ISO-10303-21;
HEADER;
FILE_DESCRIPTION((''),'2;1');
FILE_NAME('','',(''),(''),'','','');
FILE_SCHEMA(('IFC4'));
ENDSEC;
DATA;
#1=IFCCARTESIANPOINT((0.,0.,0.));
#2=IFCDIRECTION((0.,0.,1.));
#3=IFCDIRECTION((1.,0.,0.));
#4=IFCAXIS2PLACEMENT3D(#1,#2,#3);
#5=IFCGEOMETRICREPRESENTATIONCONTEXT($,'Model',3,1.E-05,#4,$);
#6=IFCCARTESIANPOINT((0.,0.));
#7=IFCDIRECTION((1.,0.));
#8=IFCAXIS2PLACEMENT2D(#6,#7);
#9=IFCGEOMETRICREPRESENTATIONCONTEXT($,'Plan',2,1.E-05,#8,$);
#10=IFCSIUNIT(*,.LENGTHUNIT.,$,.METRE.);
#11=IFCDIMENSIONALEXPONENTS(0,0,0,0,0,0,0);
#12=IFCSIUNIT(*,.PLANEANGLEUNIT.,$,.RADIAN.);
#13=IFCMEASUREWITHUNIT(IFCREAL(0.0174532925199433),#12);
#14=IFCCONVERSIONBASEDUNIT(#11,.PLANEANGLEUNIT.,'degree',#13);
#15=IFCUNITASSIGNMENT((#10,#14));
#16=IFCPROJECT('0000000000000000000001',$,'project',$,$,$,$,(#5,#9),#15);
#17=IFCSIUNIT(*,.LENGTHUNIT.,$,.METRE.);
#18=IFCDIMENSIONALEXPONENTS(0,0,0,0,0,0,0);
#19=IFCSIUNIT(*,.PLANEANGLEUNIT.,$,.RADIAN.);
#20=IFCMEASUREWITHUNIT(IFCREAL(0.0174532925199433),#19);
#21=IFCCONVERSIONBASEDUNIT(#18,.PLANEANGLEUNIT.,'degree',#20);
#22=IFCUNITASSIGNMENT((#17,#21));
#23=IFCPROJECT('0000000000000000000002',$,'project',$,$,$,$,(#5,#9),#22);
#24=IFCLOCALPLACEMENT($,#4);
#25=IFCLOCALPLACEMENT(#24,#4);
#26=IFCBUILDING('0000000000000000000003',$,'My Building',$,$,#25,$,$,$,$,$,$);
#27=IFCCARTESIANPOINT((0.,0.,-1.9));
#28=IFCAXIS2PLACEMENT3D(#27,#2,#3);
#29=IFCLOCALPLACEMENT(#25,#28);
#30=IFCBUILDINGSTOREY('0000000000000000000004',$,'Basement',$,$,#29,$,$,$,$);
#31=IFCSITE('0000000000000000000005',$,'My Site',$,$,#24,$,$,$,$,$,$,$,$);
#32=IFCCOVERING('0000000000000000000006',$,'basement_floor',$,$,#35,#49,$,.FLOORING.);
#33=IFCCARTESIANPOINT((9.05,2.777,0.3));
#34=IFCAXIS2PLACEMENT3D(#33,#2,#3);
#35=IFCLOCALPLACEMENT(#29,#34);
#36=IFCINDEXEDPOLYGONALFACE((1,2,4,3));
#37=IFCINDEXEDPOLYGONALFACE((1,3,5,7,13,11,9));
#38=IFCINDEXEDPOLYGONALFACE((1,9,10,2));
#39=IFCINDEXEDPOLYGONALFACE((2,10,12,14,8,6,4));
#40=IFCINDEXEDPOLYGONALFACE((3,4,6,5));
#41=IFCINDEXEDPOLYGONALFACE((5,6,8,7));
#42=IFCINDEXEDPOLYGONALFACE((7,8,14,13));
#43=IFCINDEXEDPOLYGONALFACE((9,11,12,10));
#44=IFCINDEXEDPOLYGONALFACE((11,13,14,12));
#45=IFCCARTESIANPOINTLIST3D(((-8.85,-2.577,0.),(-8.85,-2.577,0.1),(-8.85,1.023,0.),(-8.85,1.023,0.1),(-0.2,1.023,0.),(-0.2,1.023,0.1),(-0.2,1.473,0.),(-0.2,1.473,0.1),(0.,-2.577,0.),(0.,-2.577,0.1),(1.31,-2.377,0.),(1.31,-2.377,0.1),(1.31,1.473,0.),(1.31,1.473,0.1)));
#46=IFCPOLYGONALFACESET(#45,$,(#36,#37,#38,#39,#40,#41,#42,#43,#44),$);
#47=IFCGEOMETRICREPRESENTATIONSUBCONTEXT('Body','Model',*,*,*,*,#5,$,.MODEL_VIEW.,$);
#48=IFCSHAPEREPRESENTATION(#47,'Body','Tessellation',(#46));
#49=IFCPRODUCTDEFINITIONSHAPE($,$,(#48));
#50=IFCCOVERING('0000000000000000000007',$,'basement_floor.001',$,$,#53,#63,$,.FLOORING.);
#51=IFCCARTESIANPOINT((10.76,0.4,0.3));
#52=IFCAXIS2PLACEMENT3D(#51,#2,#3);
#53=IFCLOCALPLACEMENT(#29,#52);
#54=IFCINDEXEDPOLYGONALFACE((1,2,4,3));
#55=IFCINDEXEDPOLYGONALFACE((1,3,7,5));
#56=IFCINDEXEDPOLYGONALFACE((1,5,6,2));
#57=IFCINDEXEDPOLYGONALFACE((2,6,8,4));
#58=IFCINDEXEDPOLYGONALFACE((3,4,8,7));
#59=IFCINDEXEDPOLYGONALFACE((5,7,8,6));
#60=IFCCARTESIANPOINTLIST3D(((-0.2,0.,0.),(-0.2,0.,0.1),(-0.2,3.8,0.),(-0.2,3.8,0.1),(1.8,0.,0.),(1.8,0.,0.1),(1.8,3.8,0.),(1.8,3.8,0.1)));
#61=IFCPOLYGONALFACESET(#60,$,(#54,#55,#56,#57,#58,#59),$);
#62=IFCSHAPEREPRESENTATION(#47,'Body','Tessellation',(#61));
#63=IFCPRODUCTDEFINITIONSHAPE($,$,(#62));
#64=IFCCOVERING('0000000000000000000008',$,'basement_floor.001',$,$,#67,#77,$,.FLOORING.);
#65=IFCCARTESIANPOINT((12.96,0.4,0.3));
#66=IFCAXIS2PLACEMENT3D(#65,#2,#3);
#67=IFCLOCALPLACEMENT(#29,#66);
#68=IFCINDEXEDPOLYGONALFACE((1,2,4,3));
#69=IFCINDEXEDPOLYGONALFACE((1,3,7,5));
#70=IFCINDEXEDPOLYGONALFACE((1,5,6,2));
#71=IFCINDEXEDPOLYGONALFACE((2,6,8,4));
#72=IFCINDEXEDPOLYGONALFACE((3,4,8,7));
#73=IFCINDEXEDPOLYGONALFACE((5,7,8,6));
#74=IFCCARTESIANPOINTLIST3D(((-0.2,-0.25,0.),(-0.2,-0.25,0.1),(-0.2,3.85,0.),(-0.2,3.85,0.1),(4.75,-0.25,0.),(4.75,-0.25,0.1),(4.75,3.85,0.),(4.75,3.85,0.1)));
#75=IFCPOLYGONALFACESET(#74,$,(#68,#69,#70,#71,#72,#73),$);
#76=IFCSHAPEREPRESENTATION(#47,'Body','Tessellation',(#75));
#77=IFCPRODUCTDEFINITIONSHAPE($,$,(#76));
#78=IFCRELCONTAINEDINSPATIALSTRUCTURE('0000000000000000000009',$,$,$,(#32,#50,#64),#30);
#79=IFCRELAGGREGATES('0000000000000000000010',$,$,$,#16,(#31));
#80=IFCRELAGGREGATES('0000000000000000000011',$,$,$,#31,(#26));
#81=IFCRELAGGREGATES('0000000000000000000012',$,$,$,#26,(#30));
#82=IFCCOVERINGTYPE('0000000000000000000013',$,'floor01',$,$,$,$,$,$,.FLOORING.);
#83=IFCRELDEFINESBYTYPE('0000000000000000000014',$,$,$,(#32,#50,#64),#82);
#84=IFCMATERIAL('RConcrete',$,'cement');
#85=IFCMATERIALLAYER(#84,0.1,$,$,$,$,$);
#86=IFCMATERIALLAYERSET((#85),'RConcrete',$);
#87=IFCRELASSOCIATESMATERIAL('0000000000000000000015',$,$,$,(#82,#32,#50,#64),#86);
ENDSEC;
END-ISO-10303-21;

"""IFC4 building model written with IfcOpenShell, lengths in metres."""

from ifc_helpers import new_model, entity, si_unit, converted_unit, frame, origin_with_axes, origin_2d_with_axis, place, context, subcontext, project, spatial, line, indexed_curve, outline, extrude, material, layer, layer_set, layer_usage, type_object, element, save


model = new_model("IFC4")

# Units and contexts
model_context = context("Model", 3, precision=1e-05, world=origin_with_axes())
plan_context = context("Plan", 2, precision=1e-05, world=origin_2d_with_axis())
body_context = subcontext(model_context, "Body", "Model", "MODEL_VIEW")
ifc_project_1 = project(units=[si_unit("LENGTHUNIT", "METRE"), converted_unit("PLANEANGLEUNIT", "degree", entity("IfcReal", 0.0174532925199433), si_unit("PLANEANGLEUNIT", "RADIAN"), dimensions=[0, 0, 0, 0, 0, 0, 0])], contexts=[model_context, plan_context])
ifc_project_2 = project(units=[si_unit("LENGTHUNIT", "METRE"), converted_unit("PLANEANGLEUNIT", "degree", entity("IfcReal", 0.0174532925199433), si_unit("PLANEANGLEUNIT", "RADIAN"), dimensions=[0, 0, 0, 0, 0, 0, 0])], contexts=[model_context, plan_context])

# Site, building, storey
site_placement = place(None, origin_with_axes())
site = spatial("IfcSite", under=ifc_project_1, at=site_placement, Name="My Site")
building_placement = place(site_placement, origin_with_axes())
building = spatial("IfcBuilding", under=site, at=building_placement, Name="My Building")
storey_placement = place(building_placement, frame((0.0, 0.0, -1.9), z_axis=(0.0, 0.0, 1.0), x_axis=(1.0, 0.0, 0.0)))
storey = spatial("IfcBuildingStorey", under=building, at=storey_placement, Name="Basement")

# Shared definitions
ifc_material_1 = material(Name="RConcrete", Category="cement")

# Coverings
ifc_layer_1 = layer(ifc_material_1, 0.1)
ifc_layer_set_1 = layer_set([ifc_layer_1], Name="RConcrete")
ifc_layer_usage_1 = layer_usage(ifc_layer_set_1, "AXIS3", "POSITIVE", 0.0)
covering_type = type_object("IfcCoveringType", Name="floor01", PredefinedType="FLOORING", material=ifc_layer_set_1)
covering_1_placement = place(storey_placement, frame((9.05, 2.777, 0.3), z_axis=(0.0, 0.0, 1.0), x_axis=(1.0, 0.0, 0.0)))
element("IfcCovering", 1, at=covering_1_placement, inside=storey, type_object=covering_type, material=ifc_layer_usage_1, Name="basement_floor", PredefinedType="FLOORING", context=body_context, shape_type="SweptSolid", body=[
    extrude(outline(indexed_curve([(1.31, 1.473), (1.31, -2.377), (0.0, -2.577), (-8.85, -2.577), (-8.85, 1.023), (-0.2, 1.023), (-0.2, 1.473)], segments=[line(2, 1), line(1, 7), line(7, 6), line(6, 5), line(5, 4), line(4, 3), line(3, 2)], self_intersect=False)), None, (0.0, 0.0, 1.0), 0.1),
])
ifc_layer_usage_2 = layer_usage(ifc_layer_set_1, "AXIS3", "POSITIVE", 0.0)
covering_2_placement = place(storey_placement, frame((10.76, 0.4, 0.3), z_axis=(0.0, 0.0, 1.0), x_axis=(1.0, 0.0, 0.0)))
element("IfcCovering", 2, at=covering_2_placement, inside=storey, type_object=covering_type, material=ifc_layer_usage_2, Name="basement_floor.001", PredefinedType="FLOORING", context=body_context, shape_type="SweptSolid", body=[
    extrude(outline(indexed_curve([(1.8, 3.8), (1.8, 0.0), (-0.2, 0.0), (-0.2, 3.8)], segments=[line(3, 2), line(2, 1), line(1, 4), line(4, 3)], self_intersect=False)), None, (0.0, 0.0, 1.0), 0.1),
])
ifc_layer_usage_3 = layer_usage(ifc_layer_set_1, "AXIS3", "POSITIVE", 0.0)
covering_3_placement = place(storey_placement, frame((12.96, 0.4, 0.3), z_axis=(0.0, 0.0, 1.0), x_axis=(1.0, 0.0, 0.0)))
element("IfcCovering", 3, at=covering_3_placement, inside=storey, type_object=covering_type, material=ifc_layer_usage_3, Name="basement_floor.001", PredefinedType="FLOORING", context=body_context, shape_type="SweptSolid", body=[
    extrude(outline(indexed_curve([(-0.2, -0.25), (4.75, -0.25), (4.75, 3.85), (-0.2, 3.85)], segments=[line(3, 2), line(2, 1), line(1, 4), line(4, 3)], self_intersect=False)), None, (0.0, 0.0, 1.0), 0.1),
])

save(model, "model.ifc")
